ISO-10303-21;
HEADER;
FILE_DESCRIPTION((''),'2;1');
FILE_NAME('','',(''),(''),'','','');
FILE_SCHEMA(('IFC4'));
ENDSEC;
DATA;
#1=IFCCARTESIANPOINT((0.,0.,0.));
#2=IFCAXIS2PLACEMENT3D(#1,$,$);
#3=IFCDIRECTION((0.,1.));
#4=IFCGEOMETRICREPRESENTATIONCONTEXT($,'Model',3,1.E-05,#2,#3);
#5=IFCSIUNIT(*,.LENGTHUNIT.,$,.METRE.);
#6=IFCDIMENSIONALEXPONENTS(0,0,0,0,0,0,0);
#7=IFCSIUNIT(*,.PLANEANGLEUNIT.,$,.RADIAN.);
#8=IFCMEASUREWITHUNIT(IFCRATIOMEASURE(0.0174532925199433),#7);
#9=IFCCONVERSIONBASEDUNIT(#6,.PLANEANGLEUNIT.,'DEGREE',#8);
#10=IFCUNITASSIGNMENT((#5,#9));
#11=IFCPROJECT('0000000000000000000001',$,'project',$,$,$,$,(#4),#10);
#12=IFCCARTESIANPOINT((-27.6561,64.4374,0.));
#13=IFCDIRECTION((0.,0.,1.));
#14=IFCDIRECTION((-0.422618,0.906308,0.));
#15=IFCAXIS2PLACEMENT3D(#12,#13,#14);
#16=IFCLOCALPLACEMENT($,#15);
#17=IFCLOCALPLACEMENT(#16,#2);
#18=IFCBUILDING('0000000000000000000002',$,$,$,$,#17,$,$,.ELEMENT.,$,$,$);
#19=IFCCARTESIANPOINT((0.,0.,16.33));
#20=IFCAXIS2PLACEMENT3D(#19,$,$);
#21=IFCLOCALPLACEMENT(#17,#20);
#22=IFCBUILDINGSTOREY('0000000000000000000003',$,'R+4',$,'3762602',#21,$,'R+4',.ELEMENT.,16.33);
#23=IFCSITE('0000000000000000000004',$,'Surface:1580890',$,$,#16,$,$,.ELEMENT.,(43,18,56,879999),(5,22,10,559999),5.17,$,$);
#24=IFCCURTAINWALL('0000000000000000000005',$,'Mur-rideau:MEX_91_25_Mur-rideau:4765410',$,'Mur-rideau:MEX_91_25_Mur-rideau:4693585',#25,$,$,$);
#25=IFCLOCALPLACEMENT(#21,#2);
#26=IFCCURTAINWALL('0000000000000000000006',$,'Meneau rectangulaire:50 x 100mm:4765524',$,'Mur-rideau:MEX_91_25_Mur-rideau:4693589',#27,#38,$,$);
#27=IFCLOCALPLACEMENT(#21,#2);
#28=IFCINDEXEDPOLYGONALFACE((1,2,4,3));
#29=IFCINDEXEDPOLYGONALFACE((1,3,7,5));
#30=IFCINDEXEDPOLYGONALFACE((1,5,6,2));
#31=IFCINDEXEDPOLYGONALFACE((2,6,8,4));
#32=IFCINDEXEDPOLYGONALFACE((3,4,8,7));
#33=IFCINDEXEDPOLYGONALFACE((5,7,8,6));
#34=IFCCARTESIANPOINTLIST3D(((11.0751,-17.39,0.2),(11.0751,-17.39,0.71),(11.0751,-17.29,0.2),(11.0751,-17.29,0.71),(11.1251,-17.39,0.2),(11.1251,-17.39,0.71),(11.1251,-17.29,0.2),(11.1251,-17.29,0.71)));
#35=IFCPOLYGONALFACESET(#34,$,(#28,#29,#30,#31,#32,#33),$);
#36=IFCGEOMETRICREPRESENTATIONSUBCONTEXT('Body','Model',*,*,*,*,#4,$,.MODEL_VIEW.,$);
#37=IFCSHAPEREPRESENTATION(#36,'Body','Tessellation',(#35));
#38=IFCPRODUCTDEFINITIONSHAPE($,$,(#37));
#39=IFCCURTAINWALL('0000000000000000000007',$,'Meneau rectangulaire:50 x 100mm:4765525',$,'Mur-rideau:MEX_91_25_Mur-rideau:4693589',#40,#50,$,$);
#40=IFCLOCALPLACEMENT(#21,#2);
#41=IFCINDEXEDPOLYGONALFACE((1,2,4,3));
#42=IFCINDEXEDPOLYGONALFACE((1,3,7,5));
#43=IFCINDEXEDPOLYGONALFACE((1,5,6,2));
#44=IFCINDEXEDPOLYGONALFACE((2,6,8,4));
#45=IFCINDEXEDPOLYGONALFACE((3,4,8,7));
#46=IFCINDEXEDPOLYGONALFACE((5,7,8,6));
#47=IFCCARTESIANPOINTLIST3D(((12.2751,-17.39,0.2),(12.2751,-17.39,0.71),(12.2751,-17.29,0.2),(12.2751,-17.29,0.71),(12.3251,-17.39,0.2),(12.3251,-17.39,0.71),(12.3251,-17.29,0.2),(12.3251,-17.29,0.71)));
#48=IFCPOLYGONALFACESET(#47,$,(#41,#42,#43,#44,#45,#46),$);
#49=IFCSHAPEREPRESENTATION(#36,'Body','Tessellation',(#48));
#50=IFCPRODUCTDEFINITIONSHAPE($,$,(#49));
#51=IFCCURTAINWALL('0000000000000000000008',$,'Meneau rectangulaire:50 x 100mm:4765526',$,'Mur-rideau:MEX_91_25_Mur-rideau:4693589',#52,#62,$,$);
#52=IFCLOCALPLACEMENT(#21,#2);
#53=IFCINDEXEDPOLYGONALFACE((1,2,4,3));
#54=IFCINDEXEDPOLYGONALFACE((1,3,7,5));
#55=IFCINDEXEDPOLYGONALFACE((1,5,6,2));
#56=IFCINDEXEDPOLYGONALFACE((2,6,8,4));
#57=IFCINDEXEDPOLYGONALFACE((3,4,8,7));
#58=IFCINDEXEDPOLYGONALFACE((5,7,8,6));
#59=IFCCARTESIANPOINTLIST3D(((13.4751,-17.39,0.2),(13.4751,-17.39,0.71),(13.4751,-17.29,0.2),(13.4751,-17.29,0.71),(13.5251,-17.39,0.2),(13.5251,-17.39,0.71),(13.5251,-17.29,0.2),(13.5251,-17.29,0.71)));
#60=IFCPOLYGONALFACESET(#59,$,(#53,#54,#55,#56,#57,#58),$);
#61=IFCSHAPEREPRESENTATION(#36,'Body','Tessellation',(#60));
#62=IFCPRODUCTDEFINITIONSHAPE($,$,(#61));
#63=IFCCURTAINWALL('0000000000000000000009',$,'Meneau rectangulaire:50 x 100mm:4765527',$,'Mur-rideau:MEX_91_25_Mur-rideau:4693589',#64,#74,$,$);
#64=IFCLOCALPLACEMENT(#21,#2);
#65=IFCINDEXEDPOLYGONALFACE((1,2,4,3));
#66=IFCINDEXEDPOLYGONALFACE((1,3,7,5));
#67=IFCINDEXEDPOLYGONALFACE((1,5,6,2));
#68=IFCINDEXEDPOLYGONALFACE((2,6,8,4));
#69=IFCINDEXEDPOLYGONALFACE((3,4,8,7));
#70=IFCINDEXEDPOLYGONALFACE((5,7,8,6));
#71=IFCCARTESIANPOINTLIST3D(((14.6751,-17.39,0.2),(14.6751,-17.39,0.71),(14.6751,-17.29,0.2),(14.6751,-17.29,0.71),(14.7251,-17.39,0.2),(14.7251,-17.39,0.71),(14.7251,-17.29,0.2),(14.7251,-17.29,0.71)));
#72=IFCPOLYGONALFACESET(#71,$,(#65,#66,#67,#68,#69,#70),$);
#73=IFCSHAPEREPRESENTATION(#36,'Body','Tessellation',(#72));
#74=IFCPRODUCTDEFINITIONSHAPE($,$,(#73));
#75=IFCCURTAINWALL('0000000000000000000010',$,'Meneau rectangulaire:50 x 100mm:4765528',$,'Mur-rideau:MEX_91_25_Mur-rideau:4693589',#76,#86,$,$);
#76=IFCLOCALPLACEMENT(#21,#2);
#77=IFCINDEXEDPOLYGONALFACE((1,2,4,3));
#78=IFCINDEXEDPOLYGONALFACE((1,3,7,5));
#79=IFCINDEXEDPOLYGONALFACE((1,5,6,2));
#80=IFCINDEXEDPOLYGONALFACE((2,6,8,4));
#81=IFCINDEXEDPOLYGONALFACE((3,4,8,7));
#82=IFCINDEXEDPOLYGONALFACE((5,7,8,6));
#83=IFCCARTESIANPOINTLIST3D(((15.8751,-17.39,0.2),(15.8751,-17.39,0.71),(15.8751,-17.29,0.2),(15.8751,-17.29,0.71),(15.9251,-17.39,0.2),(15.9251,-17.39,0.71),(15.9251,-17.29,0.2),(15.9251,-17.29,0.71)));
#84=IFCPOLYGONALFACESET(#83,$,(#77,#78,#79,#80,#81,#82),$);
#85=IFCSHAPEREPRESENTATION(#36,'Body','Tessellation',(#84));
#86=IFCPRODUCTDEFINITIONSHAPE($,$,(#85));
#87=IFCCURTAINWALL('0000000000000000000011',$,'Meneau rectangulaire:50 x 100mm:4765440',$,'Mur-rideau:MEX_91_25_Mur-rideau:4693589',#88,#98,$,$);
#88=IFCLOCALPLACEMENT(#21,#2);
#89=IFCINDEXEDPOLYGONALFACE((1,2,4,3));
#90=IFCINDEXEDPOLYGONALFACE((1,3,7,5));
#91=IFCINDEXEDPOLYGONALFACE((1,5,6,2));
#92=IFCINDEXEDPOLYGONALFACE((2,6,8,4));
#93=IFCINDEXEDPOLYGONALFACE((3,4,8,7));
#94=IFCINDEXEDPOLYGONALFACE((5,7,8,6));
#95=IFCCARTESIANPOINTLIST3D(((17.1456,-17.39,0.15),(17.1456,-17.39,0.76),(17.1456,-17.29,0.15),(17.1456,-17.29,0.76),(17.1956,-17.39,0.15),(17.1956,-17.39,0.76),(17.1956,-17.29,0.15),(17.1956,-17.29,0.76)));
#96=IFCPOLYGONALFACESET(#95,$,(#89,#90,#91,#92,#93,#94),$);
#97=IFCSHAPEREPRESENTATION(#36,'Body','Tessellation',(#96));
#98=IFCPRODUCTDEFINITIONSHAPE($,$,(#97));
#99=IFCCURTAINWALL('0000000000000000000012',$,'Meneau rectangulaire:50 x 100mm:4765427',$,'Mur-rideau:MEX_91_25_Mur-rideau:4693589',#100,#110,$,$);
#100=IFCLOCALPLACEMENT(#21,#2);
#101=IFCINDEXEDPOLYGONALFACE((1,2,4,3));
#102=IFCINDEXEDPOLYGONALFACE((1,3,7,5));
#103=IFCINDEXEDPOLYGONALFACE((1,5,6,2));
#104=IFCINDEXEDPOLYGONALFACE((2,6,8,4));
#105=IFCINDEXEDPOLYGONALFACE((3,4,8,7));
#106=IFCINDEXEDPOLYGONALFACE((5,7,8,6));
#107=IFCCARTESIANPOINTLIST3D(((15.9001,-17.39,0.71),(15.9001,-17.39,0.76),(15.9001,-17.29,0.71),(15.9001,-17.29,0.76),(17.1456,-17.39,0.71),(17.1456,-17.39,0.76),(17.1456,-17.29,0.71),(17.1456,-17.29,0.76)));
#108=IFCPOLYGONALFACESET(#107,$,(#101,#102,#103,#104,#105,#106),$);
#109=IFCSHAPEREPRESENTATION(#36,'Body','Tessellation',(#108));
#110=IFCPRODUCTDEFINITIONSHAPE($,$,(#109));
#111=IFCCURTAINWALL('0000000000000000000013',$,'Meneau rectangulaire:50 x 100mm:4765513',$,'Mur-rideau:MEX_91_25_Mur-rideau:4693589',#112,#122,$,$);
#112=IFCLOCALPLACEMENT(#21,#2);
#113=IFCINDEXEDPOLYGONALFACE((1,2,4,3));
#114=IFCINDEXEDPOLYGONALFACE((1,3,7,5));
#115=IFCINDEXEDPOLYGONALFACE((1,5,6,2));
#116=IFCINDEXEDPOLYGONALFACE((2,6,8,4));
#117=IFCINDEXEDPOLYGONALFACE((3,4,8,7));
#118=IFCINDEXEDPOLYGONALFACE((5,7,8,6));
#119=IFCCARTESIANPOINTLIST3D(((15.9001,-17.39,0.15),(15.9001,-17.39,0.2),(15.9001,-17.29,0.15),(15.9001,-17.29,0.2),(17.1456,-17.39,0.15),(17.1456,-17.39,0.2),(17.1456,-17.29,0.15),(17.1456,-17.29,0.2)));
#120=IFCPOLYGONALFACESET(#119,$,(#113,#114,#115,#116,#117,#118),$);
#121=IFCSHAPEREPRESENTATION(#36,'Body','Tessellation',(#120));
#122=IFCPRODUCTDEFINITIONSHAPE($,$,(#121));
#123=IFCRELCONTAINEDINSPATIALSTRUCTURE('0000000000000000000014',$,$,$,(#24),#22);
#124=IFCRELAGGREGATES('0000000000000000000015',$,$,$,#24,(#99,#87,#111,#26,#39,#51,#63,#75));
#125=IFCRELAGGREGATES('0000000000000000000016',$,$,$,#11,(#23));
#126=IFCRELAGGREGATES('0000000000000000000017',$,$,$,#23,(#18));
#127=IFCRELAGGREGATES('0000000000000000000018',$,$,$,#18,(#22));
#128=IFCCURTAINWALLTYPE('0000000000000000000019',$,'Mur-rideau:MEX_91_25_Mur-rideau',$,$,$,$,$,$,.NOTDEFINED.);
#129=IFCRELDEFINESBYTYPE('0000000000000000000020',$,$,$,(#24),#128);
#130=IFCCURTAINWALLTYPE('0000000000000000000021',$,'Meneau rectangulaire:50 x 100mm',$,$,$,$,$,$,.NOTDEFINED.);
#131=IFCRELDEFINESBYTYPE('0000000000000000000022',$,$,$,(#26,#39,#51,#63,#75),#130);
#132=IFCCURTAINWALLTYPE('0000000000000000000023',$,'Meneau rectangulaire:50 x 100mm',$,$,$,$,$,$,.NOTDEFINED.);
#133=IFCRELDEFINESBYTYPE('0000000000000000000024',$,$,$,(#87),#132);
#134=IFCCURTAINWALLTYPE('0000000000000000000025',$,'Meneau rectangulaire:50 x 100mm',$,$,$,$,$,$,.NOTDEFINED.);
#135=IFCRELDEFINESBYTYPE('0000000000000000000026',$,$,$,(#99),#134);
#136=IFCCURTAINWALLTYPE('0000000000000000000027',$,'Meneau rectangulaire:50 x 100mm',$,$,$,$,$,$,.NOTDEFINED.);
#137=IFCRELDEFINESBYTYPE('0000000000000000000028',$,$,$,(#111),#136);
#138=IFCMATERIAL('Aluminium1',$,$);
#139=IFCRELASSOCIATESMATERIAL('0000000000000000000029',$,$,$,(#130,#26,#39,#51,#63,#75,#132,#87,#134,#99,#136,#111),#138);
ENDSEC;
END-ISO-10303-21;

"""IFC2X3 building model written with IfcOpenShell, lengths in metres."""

from ifc_helpers import new_model, entity, si_unit, converted_unit, direction, frame, origin, origin_2d_with_axis, place, context, subcontext, project, spatial, rectangle, extrude, source, transform, mapped, material, type_object, type_shapes, element, aggregate, save


model = new_model("IFC2X3")

# Units and contexts
model_context = context("Model", 3, precision=1e-05, world=origin(), true_north=direction((0.0, 1.0)))
body_context = subcontext(model_context, "Body", "Model", "MODEL_VIEW")
ifc_project = project(units=[si_unit("LENGTHUNIT", "METRE"), converted_unit("PLANEANGLEUNIT", "DEGREE", entity("IfcRatioMeasure", 0.0174532925199433), si_unit("PLANEANGLEUNIT", "RADIAN"), dimensions=[0, 0, 0, 0, 0, 0, 0])], contexts=[model_context])

# Site, building, storey
site_placement = place(None, frame((-27.6561, 64.4374, 0.0), z_axis=(0.0, 0.0, 1.0), x_axis=(-0.422618, 0.906308, 0.0)))
site = spatial("IfcSite", under=ifc_project, at=site_placement, Name="Surface:1580890", CompositionType="ELEMENT", RefLatitude=(43, 18, 56, 879999), RefLongitude=(5, 22, 10, 559999), RefElevation=5.17)
building_placement = place(site_placement, origin())
building = spatial("IfcBuilding", under=site, at=building_placement, CompositionType="ELEMENT")
storey_placement = place(building_placement, frame((0.0, 0.0, 16.33)))
storey = spatial("IfcBuildingStorey", under=building, at=storey_placement, Name="R+4", ObjectType="3762602", LongName="R+4", CompositionType="ELEMENT", Elevation=16.33)

# Curtain wall
curtain_wall_type_1 = type_object("IfcCurtainWallType", Name="Mur-rideau:MEX_91_25_Mur-rideau", PredefinedType="NOTDEFINED")
ifc_material = material(Name="Aluminium1")
placement = place(building_placement, frame((0.0, 0.0, -2.88)))
curtain_wall_1_placement = place(storey_placement, frame((0.0, 0.0, -16.33)))
curtain_wall_1 = element("IfcCurtainWall", 1, at=curtain_wall_1_placement, inside=storey, type_object=curtain_wall_type_1, Name="Mur-rideau:MEX_91_25_Mur-rideau:4765410", ObjectType="Mur-rideau:MEX_91_25_Mur-rideau:4693585")

# Curtain walls
curtain_wall_type_2 = type_object("IfcCurtainWallType", Name="Meneau rectangulaire:50 x 100mm", PredefinedType="NOTDEFINED", material=ifc_material)
shared_shape_1 = source(origin(), body_context, "Body", "SweptSolid", [
    extrude(rectangle(XDim=0.05, YDim=0.1, at=origin_2d_with_axis()), frame((0.0, 0.0, -0.51), z_axis=(0.0, 0.0, 1.0), x_axis=(-1.0, 0.0, 0.0)), (0.0, 0.0, 1.0), 0.51),
])
type_shapes(curtain_wall_type_2, [shared_shape_1])
curtain_wall_2_placement = place(placement, frame((11.1001, -17.34, 19.41), z_axis=(0.0, 0.0, -1.0), x_axis=(1.0, 0.0, 0.0)))
curtain_wall_2 = element("IfcCurtainWall", 2, at=curtain_wall_2_placement, type_object=curtain_wall_type_2, material=ifc_material, Name="Meneau rectangulaire:50 x 100mm:4765524", ObjectType="Mur-rideau:MEX_91_25_Mur-rideau:4693589", context=body_context, shape_type="MappedRepresentation", body=[
    mapped(shared_shape_1, transform((0.0, 0.0, 0.0), scale=1.0)),
])
curtain_wall_3_placement = place(placement, frame((12.3001, -17.34, 19.41), z_axis=(0.0, 0.0, -1.0), x_axis=(1.0, 0.0, 0.0)))
curtain_wall_3 = element("IfcCurtainWall", 3, at=curtain_wall_3_placement, type_object=curtain_wall_type_2, material=ifc_material, Name="Meneau rectangulaire:50 x 100mm:4765525", ObjectType="Mur-rideau:MEX_91_25_Mur-rideau:4693589", context=body_context, shape_type="MappedRepresentation", body=[
    mapped(shared_shape_1, transform((0.0, 0.0, 0.0), scale=1.0)),
])
curtain_wall_4_placement = place(placement, frame((13.5001, -17.34, 19.41), z_axis=(0.0, 0.0, -1.0), x_axis=(1.0, 0.0, 0.0)))
curtain_wall_4 = element("IfcCurtainWall", 4, at=curtain_wall_4_placement, type_object=curtain_wall_type_2, material=ifc_material, Name="Meneau rectangulaire:50 x 100mm:4765526", ObjectType="Mur-rideau:MEX_91_25_Mur-rideau:4693589", context=body_context, shape_type="MappedRepresentation", body=[
    mapped(shared_shape_1, transform((0.0, 0.0, 0.0), scale=1.0)),
])
curtain_wall_5_placement = place(placement, frame((14.7001, -17.34, 19.41), z_axis=(0.0, 0.0, -1.0), x_axis=(1.0, 0.0, 0.0)))
curtain_wall_5 = element("IfcCurtainWall", 5, at=curtain_wall_5_placement, type_object=curtain_wall_type_2, material=ifc_material, Name="Meneau rectangulaire:50 x 100mm:4765527", ObjectType="Mur-rideau:MEX_91_25_Mur-rideau:4693589", context=body_context, shape_type="MappedRepresentation", body=[
    mapped(shared_shape_1, transform((0.0, 0.0, 0.0), scale=1.0)),
])
curtain_wall_6_placement = place(placement, frame((15.9001, -17.34, 19.41), z_axis=(0.0, 0.0, -1.0), x_axis=(1.0, 0.0, 0.0)))
curtain_wall_6 = element("IfcCurtainWall", 6, at=curtain_wall_6_placement, type_object=curtain_wall_type_2, material=ifc_material, Name="Meneau rectangulaire:50 x 100mm:4765528", ObjectType="Mur-rideau:MEX_91_25_Mur-rideau:4693589", context=body_context, shape_type="MappedRepresentation", body=[
    mapped(shared_shape_1, transform((0.0, 0.0, 0.0), scale=1.0)),
])
curtain_wall_type_3 = type_object("IfcCurtainWallType", Name="Meneau rectangulaire:50 x 100mm", PredefinedType="NOTDEFINED", material=ifc_material)
shared_shape_2 = source(origin(), body_context, "Body", "SweptSolid", [
    extrude(rectangle(XDim=0.05, YDim=0.1, at=origin_2d_with_axis()), frame((-0.025, 0.0, -0.61), z_axis=(0.0, 0.0, 1.0), x_axis=(-1.0, 0.0, 0.0)), (0.0, 0.0, 1.0), 0.61),
])
type_shapes(curtain_wall_type_3, [shared_shape_2])
curtain_wall_7_placement = place(placement, frame((17.1956, -17.34, 19.36), z_axis=(0.0, 0.0, -1.0), x_axis=(1.0, 0.0, 0.0)))
curtain_wall_7 = element("IfcCurtainWall", 7, at=curtain_wall_7_placement, type_object=curtain_wall_type_3, material=ifc_material, Name="Meneau rectangulaire:50 x 100mm:4765440", ObjectType="Mur-rideau:MEX_91_25_Mur-rideau:4693589", context=body_context, shape_type="MappedRepresentation", body=[
    mapped(shared_shape_2, transform((0.0, 0.0, 0.0), scale=1.0)),
])
curtain_wall_type_4 = type_object("IfcCurtainWallType", Name="Meneau rectangulaire:50 x 100mm", PredefinedType="NOTDEFINED", material=ifc_material)
shared_shape_3 = source(origin(), body_context, "Body", "SweptSolid", [
    extrude(rectangle(XDim=0.05, YDim=0.1, at=origin_2d_with_axis()), frame((-0.025, 0.0, -1.2455), z_axis=(0.0, 0.0, 1.0), x_axis=(-1.0, 0.0, 0.0)), (0.0, 0.0, 1.0), 1.2455),
])
type_shapes(curtain_wall_type_4, [shared_shape_3])
curtain_wall_8_placement = place(placement, frame((17.1456, -17.34, 19.97), z_axis=(1.0, 0.0, 0.0), x_axis=(0.0, 0.0, 1.0)))
curtain_wall_8 = element("IfcCurtainWall", 8, at=curtain_wall_8_placement, type_object=curtain_wall_type_4, material=ifc_material, Name="Meneau rectangulaire:50 x 100mm:4765427", ObjectType="Mur-rideau:MEX_91_25_Mur-rideau:4693589", context=body_context, shape_type="MappedRepresentation", body=[
    mapped(shared_shape_3, transform((0.0, 0.0, 0.0), scale=1.0)),
])
curtain_wall_type_5 = type_object("IfcCurtainWallType", Name="Meneau rectangulaire:50 x 100mm", PredefinedType="NOTDEFINED", material=ifc_material)
shared_shape_4 = source(origin(), body_context, "Body", "SweptSolid", [
    extrude(rectangle(XDim=0.05, YDim=0.1, at=origin_2d_with_axis()), frame((-0.025, 0.0, -1.2455), z_axis=(0.0, 0.0, 1.0), x_axis=(-1.0, 0.0, 0.0)), (0.0, 0.0, 1.0), 1.2455),
])
type_shapes(curtain_wall_type_5, [shared_shape_4])
curtain_wall_9_placement = place(placement, frame((15.9001, -17.34, 19.36), z_axis=(-1.0, 0.0, 0.0), x_axis=(0.0, 0.0, -1.0)))
curtain_wall_9 = element("IfcCurtainWall", 9, at=curtain_wall_9_placement, type_object=curtain_wall_type_5, material=ifc_material, Name="Meneau rectangulaire:50 x 100mm:4765513", ObjectType="Mur-rideau:MEX_91_25_Mur-rideau:4693589", context=body_context, shape_type="MappedRepresentation", body=[
    mapped(shared_shape_4, transform((0.0, 0.0, 0.0), scale=1.0)),
])
aggregate(curtain_wall_1, [curtain_wall_8, curtain_wall_7, curtain_wall_9, curtain_wall_2, curtain_wall_3, curtain_wall_4, curtain_wall_5, curtain_wall_6])

save(model, "model.ifc")
